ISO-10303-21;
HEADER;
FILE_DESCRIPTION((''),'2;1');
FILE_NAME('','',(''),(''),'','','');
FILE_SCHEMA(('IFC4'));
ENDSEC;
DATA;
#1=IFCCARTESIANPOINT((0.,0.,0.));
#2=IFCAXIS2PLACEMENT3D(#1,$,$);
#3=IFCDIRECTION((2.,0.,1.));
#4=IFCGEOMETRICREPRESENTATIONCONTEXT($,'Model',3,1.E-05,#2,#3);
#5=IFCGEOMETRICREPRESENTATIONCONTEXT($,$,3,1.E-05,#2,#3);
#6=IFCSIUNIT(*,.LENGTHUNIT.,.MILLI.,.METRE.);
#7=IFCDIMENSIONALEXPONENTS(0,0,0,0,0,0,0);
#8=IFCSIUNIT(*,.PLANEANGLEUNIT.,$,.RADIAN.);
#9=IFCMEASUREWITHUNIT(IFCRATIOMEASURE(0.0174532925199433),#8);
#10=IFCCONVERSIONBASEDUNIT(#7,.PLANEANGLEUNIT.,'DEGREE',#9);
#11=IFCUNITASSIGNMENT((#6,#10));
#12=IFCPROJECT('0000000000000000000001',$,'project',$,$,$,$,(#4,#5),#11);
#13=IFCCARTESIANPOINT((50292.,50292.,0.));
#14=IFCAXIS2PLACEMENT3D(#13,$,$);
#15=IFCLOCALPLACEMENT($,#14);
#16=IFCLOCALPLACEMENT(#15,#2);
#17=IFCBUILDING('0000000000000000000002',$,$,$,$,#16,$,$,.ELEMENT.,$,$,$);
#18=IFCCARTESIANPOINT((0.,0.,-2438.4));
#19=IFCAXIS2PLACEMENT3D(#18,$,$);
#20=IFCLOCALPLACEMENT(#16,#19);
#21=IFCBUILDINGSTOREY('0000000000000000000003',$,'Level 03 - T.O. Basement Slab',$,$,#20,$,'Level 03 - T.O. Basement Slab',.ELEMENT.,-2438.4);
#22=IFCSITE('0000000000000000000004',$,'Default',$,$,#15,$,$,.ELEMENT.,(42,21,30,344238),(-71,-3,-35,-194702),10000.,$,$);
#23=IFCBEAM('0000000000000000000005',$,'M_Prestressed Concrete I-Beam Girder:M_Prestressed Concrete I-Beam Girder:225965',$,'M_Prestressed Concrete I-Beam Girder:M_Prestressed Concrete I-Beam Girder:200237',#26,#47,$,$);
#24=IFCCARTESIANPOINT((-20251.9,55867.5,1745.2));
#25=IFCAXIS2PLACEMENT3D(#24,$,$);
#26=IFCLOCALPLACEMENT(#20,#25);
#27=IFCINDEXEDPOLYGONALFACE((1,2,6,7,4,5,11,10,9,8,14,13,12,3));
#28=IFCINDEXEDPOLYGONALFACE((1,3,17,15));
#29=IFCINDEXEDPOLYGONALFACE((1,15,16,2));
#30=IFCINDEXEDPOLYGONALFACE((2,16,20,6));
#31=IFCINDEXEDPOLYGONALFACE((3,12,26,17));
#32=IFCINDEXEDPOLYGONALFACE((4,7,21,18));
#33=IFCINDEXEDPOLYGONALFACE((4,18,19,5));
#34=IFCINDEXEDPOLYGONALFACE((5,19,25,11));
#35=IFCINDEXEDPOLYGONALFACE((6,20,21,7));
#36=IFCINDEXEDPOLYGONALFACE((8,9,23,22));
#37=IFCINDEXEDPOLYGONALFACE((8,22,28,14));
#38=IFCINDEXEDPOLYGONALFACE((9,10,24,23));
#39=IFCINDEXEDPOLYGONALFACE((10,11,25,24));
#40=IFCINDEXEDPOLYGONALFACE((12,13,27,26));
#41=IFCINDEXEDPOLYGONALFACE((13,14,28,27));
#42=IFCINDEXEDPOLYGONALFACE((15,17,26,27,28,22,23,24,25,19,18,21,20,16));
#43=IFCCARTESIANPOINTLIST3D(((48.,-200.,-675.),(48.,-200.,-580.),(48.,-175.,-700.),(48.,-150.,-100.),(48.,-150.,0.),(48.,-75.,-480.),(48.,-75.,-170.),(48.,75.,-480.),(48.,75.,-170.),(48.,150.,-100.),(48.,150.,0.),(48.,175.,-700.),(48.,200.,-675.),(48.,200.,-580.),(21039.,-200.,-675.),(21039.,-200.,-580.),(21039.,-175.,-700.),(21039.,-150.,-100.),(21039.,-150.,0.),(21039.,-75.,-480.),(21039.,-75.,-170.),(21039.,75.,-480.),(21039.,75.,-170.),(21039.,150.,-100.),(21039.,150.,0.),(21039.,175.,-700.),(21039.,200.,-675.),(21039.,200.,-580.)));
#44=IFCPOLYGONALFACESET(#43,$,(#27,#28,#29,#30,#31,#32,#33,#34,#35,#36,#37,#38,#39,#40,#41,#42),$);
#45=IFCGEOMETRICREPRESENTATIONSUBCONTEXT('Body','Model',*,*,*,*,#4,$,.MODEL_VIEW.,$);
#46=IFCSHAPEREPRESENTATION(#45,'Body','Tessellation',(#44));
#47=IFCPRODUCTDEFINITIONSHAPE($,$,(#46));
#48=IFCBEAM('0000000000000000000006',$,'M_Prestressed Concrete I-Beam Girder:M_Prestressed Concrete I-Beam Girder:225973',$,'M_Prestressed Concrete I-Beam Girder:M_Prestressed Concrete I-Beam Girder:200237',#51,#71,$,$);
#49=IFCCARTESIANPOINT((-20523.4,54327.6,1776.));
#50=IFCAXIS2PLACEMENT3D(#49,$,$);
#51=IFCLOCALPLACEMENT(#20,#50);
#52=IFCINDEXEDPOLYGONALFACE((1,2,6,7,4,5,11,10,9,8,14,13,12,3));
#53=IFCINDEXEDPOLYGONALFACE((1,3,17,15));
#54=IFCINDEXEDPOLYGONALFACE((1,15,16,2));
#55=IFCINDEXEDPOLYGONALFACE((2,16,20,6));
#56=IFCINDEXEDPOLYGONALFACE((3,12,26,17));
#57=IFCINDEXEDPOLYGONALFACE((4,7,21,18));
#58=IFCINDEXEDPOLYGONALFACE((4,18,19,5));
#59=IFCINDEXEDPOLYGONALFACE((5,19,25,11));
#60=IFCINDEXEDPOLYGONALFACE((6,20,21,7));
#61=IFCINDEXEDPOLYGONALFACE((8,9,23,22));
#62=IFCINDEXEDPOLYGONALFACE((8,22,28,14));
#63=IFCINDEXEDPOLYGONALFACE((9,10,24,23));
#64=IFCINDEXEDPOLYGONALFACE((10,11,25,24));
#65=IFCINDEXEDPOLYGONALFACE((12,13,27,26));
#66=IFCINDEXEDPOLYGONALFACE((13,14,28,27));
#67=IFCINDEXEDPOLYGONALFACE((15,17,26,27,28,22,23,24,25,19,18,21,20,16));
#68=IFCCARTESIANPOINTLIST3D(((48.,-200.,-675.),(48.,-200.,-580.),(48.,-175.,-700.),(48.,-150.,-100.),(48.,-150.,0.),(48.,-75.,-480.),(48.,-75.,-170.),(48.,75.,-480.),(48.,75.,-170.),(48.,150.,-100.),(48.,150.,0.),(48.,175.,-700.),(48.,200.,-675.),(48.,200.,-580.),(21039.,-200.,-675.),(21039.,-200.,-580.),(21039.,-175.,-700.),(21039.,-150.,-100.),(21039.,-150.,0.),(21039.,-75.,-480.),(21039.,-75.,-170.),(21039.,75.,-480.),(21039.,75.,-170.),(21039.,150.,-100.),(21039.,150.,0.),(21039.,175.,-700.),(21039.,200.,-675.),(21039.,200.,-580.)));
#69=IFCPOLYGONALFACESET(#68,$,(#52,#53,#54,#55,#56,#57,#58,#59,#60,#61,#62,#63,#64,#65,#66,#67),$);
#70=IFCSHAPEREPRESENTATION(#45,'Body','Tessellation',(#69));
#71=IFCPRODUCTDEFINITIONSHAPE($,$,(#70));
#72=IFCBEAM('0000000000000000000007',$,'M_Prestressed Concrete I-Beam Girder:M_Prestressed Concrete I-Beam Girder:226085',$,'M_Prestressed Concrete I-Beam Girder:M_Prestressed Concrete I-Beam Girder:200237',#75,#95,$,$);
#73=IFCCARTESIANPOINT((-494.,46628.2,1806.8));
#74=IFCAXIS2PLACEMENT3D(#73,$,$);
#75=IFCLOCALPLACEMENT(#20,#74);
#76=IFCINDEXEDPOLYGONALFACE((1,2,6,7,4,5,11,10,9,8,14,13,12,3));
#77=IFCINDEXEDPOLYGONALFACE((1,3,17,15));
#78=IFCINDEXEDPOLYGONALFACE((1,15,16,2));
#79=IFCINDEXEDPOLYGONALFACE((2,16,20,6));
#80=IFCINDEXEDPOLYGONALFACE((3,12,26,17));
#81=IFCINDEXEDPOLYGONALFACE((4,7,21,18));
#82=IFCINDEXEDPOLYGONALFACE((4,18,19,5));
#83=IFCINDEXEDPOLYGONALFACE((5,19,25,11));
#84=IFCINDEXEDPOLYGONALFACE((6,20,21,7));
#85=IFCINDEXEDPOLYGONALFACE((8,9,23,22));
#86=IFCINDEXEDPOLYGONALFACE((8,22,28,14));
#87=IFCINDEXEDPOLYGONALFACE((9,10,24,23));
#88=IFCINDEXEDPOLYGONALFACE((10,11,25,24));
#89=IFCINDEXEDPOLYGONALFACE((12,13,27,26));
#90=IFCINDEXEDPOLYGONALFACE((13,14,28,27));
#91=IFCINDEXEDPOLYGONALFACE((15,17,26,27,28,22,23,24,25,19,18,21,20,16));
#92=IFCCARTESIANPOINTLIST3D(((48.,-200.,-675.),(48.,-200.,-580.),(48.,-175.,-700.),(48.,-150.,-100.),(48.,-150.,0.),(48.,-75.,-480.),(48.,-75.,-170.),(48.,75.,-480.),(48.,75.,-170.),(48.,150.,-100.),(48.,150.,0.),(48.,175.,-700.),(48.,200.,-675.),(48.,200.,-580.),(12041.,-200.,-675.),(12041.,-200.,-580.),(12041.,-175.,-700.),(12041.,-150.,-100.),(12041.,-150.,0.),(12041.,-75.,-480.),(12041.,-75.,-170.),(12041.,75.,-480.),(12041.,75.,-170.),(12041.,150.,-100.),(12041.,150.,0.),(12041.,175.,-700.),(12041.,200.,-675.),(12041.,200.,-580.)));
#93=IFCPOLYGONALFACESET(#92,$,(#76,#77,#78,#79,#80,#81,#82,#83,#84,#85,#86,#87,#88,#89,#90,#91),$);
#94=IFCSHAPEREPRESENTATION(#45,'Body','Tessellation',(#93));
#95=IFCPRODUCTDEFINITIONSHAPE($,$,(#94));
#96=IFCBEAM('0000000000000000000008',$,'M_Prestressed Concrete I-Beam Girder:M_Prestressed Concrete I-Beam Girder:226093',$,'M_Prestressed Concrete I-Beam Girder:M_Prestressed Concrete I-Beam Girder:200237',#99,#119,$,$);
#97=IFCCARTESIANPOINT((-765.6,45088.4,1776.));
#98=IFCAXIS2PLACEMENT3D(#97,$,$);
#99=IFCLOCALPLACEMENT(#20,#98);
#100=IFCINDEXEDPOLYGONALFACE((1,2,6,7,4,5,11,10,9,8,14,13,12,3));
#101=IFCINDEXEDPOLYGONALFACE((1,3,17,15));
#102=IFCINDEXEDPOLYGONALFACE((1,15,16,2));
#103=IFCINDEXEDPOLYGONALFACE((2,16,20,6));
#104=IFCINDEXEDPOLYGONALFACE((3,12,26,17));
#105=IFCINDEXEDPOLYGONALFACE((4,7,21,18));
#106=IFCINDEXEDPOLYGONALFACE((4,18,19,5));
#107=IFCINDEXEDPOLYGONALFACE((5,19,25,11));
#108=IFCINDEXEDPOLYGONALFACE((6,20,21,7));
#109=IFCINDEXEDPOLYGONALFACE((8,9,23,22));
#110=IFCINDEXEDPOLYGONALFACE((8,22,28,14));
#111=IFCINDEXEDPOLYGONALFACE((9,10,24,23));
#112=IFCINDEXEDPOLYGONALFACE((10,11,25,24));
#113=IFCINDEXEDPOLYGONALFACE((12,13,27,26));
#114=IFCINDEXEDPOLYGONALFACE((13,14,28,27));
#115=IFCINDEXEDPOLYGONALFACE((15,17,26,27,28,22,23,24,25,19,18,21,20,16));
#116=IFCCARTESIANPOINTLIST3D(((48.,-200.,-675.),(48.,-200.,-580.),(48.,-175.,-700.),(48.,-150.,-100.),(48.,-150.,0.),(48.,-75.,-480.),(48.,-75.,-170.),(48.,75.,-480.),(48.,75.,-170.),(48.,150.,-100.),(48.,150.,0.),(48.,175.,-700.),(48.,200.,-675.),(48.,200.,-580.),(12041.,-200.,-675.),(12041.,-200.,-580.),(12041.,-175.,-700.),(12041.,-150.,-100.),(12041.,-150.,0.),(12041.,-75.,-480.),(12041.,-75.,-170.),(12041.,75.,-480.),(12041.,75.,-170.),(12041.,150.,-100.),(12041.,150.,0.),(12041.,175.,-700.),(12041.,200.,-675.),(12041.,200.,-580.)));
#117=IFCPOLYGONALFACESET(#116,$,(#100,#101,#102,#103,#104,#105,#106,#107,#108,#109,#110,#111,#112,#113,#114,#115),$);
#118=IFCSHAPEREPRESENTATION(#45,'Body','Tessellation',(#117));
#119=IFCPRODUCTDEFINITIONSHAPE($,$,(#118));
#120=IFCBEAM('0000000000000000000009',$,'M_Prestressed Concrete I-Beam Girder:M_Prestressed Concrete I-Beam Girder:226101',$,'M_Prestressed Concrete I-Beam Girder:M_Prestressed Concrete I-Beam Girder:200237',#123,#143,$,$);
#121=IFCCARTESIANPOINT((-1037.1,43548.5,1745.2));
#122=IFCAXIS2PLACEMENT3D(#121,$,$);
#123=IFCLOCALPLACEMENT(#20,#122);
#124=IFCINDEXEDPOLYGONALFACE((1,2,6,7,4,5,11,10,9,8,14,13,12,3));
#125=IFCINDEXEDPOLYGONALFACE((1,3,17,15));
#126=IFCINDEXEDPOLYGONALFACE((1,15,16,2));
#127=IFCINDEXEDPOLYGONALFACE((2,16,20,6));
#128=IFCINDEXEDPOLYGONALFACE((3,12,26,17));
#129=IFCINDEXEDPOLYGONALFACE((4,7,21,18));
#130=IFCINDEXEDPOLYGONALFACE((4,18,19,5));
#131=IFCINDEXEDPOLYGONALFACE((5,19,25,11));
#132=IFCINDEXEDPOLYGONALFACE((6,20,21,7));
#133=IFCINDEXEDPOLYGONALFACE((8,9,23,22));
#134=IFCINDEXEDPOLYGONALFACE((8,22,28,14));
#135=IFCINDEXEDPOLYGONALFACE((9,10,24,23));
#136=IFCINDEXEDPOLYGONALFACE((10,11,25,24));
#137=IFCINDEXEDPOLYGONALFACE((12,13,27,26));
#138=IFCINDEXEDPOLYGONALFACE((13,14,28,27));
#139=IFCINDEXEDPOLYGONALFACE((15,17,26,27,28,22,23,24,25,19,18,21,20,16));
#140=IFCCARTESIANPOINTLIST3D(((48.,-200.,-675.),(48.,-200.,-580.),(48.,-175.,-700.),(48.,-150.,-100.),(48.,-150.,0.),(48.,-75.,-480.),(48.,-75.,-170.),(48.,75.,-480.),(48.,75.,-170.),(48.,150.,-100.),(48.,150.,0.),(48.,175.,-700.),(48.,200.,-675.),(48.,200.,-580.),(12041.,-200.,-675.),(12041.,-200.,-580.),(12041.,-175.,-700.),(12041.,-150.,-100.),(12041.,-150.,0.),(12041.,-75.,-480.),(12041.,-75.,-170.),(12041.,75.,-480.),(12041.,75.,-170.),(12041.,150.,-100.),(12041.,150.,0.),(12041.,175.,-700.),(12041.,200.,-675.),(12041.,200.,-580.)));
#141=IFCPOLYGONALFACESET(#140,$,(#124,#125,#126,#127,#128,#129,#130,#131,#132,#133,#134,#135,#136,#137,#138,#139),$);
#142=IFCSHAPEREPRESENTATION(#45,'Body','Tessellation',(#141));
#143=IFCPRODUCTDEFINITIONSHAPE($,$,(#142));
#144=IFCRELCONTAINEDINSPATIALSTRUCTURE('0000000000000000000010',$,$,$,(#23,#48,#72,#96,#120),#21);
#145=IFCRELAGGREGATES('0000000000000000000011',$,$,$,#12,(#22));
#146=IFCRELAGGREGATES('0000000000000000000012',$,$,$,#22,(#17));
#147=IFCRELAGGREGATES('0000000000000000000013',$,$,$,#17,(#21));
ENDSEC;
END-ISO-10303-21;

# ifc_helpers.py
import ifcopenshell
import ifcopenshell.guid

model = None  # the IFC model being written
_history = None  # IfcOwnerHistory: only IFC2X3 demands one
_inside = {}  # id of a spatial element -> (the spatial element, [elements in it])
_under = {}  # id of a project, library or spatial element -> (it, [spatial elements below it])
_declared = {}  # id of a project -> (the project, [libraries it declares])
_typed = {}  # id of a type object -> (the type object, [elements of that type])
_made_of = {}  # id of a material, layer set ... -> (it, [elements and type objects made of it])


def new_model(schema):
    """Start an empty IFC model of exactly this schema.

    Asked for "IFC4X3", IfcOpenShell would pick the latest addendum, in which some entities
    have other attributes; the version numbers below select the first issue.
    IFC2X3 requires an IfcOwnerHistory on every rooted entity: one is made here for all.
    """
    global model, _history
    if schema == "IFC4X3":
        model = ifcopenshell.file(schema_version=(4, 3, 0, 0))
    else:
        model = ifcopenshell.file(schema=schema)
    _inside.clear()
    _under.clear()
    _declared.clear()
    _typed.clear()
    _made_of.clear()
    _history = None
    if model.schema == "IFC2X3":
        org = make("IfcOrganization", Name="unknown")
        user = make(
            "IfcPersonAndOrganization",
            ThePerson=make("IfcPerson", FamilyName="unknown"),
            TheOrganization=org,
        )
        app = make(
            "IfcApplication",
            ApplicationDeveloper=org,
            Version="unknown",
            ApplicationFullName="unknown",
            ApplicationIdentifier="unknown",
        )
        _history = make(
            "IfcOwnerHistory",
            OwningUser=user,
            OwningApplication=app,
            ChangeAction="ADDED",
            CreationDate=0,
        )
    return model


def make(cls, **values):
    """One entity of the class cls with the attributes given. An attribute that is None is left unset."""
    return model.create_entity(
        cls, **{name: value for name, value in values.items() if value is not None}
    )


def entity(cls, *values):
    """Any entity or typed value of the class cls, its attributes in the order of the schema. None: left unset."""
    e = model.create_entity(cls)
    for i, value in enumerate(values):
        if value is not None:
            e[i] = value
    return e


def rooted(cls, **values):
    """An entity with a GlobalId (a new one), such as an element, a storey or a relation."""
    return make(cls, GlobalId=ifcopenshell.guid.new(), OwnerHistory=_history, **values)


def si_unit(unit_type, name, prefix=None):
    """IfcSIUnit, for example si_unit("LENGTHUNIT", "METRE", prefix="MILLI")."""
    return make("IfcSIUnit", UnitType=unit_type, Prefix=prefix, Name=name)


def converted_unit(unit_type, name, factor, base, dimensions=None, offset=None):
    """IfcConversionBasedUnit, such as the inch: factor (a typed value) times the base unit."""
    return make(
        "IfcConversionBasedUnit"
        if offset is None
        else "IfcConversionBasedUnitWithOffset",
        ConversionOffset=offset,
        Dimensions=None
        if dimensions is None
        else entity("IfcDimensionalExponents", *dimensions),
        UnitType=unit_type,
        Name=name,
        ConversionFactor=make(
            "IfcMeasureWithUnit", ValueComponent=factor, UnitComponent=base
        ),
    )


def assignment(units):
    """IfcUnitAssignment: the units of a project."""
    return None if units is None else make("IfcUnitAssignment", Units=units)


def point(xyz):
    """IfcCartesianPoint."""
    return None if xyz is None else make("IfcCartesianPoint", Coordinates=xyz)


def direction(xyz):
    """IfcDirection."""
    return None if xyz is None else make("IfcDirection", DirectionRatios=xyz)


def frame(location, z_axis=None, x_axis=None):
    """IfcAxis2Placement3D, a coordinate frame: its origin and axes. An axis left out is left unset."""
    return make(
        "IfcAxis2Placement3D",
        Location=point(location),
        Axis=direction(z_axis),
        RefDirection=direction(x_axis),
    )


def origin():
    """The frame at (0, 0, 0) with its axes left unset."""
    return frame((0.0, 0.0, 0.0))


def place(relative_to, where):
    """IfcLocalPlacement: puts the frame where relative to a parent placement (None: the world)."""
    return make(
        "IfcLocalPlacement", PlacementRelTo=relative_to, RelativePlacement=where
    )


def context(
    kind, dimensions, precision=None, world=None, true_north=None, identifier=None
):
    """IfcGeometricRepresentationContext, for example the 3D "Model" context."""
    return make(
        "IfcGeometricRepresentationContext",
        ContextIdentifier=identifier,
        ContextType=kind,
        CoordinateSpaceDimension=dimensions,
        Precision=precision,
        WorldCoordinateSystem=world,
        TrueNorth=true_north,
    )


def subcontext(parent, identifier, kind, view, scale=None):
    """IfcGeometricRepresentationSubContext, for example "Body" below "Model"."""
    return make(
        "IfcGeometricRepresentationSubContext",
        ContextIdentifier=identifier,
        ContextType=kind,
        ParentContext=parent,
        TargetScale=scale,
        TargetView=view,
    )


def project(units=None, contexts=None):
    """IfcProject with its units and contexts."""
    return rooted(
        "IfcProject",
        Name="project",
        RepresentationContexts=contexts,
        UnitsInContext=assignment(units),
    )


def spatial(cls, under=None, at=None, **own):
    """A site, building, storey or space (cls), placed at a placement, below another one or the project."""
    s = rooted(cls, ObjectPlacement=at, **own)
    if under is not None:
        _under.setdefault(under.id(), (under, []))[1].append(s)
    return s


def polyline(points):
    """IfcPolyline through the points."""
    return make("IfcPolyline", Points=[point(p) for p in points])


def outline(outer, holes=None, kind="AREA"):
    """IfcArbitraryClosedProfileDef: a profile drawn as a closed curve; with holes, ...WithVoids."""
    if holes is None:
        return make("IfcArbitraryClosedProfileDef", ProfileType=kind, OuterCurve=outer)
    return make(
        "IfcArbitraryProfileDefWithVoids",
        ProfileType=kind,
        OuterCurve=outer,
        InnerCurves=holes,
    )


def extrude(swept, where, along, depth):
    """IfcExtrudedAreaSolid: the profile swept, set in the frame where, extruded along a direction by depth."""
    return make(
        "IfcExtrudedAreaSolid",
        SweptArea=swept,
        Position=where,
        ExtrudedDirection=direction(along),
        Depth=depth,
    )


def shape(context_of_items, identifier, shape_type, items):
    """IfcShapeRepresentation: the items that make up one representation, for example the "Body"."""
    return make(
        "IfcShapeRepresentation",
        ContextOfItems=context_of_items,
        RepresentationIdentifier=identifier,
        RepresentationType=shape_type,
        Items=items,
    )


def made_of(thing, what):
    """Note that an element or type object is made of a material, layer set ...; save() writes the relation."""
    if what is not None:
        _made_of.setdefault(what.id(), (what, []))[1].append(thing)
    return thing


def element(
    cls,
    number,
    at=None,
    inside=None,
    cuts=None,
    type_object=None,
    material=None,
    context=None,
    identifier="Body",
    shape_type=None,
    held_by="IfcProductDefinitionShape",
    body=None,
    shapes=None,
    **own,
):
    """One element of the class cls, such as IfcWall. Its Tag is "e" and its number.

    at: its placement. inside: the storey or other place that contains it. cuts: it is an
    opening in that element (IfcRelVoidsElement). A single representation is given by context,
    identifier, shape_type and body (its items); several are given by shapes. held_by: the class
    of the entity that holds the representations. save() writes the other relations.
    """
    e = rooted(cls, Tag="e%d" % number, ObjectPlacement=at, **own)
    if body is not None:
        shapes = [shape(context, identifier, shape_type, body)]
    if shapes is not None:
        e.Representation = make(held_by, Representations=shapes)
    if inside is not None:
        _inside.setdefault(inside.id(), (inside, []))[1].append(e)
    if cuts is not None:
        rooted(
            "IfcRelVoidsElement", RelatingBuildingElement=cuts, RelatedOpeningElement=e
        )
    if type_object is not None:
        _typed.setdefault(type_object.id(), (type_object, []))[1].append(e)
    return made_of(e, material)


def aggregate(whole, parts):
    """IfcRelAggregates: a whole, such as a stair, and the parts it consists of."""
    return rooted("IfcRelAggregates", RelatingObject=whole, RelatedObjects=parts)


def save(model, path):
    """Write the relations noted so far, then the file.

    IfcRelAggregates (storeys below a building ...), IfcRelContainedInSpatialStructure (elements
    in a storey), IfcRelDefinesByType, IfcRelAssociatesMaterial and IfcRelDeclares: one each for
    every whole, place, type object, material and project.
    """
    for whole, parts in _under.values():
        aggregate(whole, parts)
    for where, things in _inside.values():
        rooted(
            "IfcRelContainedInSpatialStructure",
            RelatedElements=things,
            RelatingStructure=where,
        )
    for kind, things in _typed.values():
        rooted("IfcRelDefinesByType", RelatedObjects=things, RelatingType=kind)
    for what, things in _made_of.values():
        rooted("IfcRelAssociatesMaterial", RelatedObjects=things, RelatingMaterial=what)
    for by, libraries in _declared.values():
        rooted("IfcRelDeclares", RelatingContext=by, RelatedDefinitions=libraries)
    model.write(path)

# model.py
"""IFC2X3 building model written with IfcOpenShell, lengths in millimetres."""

from ifc_helpers import new_model, entity, si_unit, converted_unit, direction, frame, origin, place, context, subcontext, project, spatial, polyline, outline, extrude, element, save


model = new_model("IFC2X3")

# Units and contexts
model_context = context("Model", 3, precision=1e-05, world=origin(), true_north=direction((2.0, 0.0, 1.0)))
context_of_model = context(None, 3, precision=1e-05, world=origin(), true_north=direction((2.0, 0.0, 1.0)))
body_context = subcontext(model_context, "Body", "Model", "MODEL_VIEW")
ifc_project = project(units=[si_unit("LENGTHUNIT", "METRE", prefix="MILLI"), converted_unit("PLANEANGLEUNIT", "DEGREE", entity("IfcRatioMeasure", 0.0174532925199433), si_unit("PLANEANGLEUNIT", "RADIAN"), dimensions=[0, 0, 0, 0, 0, 0, 0])], contexts=[model_context, context_of_model])

# Site, building, storey
site_placement = place(None, frame((50292.0, 50292.0, 0.0)))
site = spatial("IfcSite", under=ifc_project, at=site_placement, Name="Default", CompositionType="ELEMENT", RefLatitude=(42, 21, 30, 344238), RefLongitude=(-71, -3, -35, -194702), RefElevation=10000.0)
building_placement = place(site_placement, origin())
building = spatial("IfcBuilding", under=site, at=building_placement, CompositionType="ELEMENT")
storey_placement = place(building_placement, frame((0.0, 0.0, -2438.4)))
storey = spatial("IfcBuildingStorey", under=building, at=storey_placement, Name="Level 03 - T.O. Basement Slab", LongName="Level 03 - T.O. Basement Slab", CompositionType="ELEMENT", Elevation=-2438.4)

# Beams
beam_1_placement = place(storey_placement, frame((-20251.9, 55867.5, 1745.2)))
element("IfcBeam", 1, at=beam_1_placement, inside=storey, Name="M_Prestressed Concrete I-Beam Girder:M_Prestressed Concrete I-Beam Girder:225965", ObjectType="M_Prestressed Concrete I-Beam Girder:M_Prestressed Concrete I-Beam Girder:200237", context=body_context, shape_type="SweptSolid", body=[
    extrude(outline(polyline([(193.6, -200.0), (288.6, -200.0), (313.6, -175.0), (313.6, 175.0), (288.6, 200.0), (193.6, 200.0), (93.6, 75.0), (-216.4, 75.0), (-286.4, 150.0), (-386.4, 150.0), (-386.4, -150.0), (-286.4, -150.0), (-216.4, -75.0), (93.6, -75.0), (193.6, -200.0)])), frame((48.0, 0.0, -386.4), z_axis=(1.0, 0.0, 0.0), x_axis=(0.0, 0.0, -1.0)), (0.0, 0.0, 1.0), 20991.0),
])
beam_2_placement = place(storey_placement, frame((-20523.4, 54327.6, 1776.0)))
element("IfcBeam", 2, at=beam_2_placement, inside=storey, Name="M_Prestressed Concrete I-Beam Girder:M_Prestressed Concrete I-Beam Girder:225973", ObjectType="M_Prestressed Concrete I-Beam Girder:M_Prestressed Concrete I-Beam Girder:200237", context=body_context, shape_type="SweptSolid", body=[
    extrude(outline(polyline([(193.6, -200.0), (288.6, -200.0), (313.6, -175.0), (313.6, 175.0), (288.6, 200.0), (193.6, 200.0), (93.6, 75.0), (-216.4, 75.0), (-286.4, 150.0), (-386.4, 150.0), (-386.4, -150.0), (-286.4, -150.0), (-216.4, -75.0), (93.6, -75.0), (193.6, -200.0)])), frame((48.0, 0.0, -386.4), z_axis=(1.0, 0.0, 0.0), x_axis=(0.0, 0.0, -1.0)), (0.0, 0.0, 1.0), 20991.0),
])
beam_3_placement = place(storey_placement, frame((-494.0, 46628.2, 1806.8)))
element("IfcBeam", 3, at=beam_3_placement, inside=storey, Name="M_Prestressed Concrete I-Beam Girder:M_Prestressed Concrete I-Beam Girder:226085", ObjectType="M_Prestressed Concrete I-Beam Girder:M_Prestressed Concrete I-Beam Girder:200237", context=body_context, shape_type="SweptSolid", body=[
    extrude(outline(polyline([(193.6, -200.0), (288.6, -200.0), (313.6, -175.0), (313.6, 175.0), (288.6, 200.0), (193.6, 200.0), (93.6, 75.0), (-216.4, 75.0), (-286.4, 150.0), (-386.4, 150.0), (-386.4, -150.0), (-286.4, -150.0), (-216.4, -75.0), (93.6, -75.0), (193.6, -200.0)])), frame((48.0, 0.0, -386.4), z_axis=(1.0, 0.0, 0.0), x_axis=(0.0, 0.0, -1.0)), (0.0, 0.0, 1.0), 11993.0),
])
beam_4_placement = place(storey_placement, frame((-765.6, 45088.4, 1776.0)))
element("IfcBeam", 4, at=beam_4_placement, inside=storey, Name="M_Prestressed Concrete I-Beam Girder:M_Prestressed Concrete I-Beam Girder:226093", ObjectType="M_Prestressed Concrete I-Beam Girder:M_Prestressed Concrete I-Beam Girder:200237", context=body_context, shape_type="SweptSolid", body=[
    extrude(outline(polyline([(193.6, -200.0), (288.6, -200.0), (313.6, -175.0), (313.6, 175.0), (288.6, 200.0), (193.6, 200.0), (93.6, 75.0), (-216.4, 75.0), (-286.4, 150.0), (-386.4, 150.0), (-386.4, -150.0), (-286.4, -150.0), (-216.4, -75.0), (93.6, -75.0), (193.6, -200.0)])), frame((48.0, 0.0, -386.4), z_axis=(1.0, 0.0, 0.0), x_axis=(0.0, 0.0, -1.0)), (0.0, 0.0, 1.0), 11993.0),
])
beam_5_placement = place(storey_placement, frame((-1037.1, 43548.5, 1745.2)))
element("IfcBeam", 5, at=beam_5_placement, inside=storey, Name="M_Prestressed Concrete I-Beam Girder:M_Prestressed Concrete I-Beam Girder:226101", ObjectType="M_Prestressed Concrete I-Beam Girder:M_Prestressed Concrete I-Beam Girder:200237", context=body_context, shape_type="SweptSolid", body=[
    extrude(outline(polyline([(193.6, -200.0), (288.6, -200.0), (313.6, -175.0), (313.6, 175.0), (288.6, 200.0), (193.6, 200.0), (93.6, 75.0), (-216.4, 75.0), (-286.4, 150.0), (-386.4, 150.0), (-386.4, -150.0), (-286.4, -150.0), (-216.4, -75.0), (93.6, -75.0), (193.6, -200.0)])), frame((48.0, 0.0, -386.4), z_axis=(1.0, 0.0, 0.0), x_axis=(0.0, 0.0, -1.0)), (0.0, 0.0, 1.0), 11993.0),
])

save(model, "model.ifc")
